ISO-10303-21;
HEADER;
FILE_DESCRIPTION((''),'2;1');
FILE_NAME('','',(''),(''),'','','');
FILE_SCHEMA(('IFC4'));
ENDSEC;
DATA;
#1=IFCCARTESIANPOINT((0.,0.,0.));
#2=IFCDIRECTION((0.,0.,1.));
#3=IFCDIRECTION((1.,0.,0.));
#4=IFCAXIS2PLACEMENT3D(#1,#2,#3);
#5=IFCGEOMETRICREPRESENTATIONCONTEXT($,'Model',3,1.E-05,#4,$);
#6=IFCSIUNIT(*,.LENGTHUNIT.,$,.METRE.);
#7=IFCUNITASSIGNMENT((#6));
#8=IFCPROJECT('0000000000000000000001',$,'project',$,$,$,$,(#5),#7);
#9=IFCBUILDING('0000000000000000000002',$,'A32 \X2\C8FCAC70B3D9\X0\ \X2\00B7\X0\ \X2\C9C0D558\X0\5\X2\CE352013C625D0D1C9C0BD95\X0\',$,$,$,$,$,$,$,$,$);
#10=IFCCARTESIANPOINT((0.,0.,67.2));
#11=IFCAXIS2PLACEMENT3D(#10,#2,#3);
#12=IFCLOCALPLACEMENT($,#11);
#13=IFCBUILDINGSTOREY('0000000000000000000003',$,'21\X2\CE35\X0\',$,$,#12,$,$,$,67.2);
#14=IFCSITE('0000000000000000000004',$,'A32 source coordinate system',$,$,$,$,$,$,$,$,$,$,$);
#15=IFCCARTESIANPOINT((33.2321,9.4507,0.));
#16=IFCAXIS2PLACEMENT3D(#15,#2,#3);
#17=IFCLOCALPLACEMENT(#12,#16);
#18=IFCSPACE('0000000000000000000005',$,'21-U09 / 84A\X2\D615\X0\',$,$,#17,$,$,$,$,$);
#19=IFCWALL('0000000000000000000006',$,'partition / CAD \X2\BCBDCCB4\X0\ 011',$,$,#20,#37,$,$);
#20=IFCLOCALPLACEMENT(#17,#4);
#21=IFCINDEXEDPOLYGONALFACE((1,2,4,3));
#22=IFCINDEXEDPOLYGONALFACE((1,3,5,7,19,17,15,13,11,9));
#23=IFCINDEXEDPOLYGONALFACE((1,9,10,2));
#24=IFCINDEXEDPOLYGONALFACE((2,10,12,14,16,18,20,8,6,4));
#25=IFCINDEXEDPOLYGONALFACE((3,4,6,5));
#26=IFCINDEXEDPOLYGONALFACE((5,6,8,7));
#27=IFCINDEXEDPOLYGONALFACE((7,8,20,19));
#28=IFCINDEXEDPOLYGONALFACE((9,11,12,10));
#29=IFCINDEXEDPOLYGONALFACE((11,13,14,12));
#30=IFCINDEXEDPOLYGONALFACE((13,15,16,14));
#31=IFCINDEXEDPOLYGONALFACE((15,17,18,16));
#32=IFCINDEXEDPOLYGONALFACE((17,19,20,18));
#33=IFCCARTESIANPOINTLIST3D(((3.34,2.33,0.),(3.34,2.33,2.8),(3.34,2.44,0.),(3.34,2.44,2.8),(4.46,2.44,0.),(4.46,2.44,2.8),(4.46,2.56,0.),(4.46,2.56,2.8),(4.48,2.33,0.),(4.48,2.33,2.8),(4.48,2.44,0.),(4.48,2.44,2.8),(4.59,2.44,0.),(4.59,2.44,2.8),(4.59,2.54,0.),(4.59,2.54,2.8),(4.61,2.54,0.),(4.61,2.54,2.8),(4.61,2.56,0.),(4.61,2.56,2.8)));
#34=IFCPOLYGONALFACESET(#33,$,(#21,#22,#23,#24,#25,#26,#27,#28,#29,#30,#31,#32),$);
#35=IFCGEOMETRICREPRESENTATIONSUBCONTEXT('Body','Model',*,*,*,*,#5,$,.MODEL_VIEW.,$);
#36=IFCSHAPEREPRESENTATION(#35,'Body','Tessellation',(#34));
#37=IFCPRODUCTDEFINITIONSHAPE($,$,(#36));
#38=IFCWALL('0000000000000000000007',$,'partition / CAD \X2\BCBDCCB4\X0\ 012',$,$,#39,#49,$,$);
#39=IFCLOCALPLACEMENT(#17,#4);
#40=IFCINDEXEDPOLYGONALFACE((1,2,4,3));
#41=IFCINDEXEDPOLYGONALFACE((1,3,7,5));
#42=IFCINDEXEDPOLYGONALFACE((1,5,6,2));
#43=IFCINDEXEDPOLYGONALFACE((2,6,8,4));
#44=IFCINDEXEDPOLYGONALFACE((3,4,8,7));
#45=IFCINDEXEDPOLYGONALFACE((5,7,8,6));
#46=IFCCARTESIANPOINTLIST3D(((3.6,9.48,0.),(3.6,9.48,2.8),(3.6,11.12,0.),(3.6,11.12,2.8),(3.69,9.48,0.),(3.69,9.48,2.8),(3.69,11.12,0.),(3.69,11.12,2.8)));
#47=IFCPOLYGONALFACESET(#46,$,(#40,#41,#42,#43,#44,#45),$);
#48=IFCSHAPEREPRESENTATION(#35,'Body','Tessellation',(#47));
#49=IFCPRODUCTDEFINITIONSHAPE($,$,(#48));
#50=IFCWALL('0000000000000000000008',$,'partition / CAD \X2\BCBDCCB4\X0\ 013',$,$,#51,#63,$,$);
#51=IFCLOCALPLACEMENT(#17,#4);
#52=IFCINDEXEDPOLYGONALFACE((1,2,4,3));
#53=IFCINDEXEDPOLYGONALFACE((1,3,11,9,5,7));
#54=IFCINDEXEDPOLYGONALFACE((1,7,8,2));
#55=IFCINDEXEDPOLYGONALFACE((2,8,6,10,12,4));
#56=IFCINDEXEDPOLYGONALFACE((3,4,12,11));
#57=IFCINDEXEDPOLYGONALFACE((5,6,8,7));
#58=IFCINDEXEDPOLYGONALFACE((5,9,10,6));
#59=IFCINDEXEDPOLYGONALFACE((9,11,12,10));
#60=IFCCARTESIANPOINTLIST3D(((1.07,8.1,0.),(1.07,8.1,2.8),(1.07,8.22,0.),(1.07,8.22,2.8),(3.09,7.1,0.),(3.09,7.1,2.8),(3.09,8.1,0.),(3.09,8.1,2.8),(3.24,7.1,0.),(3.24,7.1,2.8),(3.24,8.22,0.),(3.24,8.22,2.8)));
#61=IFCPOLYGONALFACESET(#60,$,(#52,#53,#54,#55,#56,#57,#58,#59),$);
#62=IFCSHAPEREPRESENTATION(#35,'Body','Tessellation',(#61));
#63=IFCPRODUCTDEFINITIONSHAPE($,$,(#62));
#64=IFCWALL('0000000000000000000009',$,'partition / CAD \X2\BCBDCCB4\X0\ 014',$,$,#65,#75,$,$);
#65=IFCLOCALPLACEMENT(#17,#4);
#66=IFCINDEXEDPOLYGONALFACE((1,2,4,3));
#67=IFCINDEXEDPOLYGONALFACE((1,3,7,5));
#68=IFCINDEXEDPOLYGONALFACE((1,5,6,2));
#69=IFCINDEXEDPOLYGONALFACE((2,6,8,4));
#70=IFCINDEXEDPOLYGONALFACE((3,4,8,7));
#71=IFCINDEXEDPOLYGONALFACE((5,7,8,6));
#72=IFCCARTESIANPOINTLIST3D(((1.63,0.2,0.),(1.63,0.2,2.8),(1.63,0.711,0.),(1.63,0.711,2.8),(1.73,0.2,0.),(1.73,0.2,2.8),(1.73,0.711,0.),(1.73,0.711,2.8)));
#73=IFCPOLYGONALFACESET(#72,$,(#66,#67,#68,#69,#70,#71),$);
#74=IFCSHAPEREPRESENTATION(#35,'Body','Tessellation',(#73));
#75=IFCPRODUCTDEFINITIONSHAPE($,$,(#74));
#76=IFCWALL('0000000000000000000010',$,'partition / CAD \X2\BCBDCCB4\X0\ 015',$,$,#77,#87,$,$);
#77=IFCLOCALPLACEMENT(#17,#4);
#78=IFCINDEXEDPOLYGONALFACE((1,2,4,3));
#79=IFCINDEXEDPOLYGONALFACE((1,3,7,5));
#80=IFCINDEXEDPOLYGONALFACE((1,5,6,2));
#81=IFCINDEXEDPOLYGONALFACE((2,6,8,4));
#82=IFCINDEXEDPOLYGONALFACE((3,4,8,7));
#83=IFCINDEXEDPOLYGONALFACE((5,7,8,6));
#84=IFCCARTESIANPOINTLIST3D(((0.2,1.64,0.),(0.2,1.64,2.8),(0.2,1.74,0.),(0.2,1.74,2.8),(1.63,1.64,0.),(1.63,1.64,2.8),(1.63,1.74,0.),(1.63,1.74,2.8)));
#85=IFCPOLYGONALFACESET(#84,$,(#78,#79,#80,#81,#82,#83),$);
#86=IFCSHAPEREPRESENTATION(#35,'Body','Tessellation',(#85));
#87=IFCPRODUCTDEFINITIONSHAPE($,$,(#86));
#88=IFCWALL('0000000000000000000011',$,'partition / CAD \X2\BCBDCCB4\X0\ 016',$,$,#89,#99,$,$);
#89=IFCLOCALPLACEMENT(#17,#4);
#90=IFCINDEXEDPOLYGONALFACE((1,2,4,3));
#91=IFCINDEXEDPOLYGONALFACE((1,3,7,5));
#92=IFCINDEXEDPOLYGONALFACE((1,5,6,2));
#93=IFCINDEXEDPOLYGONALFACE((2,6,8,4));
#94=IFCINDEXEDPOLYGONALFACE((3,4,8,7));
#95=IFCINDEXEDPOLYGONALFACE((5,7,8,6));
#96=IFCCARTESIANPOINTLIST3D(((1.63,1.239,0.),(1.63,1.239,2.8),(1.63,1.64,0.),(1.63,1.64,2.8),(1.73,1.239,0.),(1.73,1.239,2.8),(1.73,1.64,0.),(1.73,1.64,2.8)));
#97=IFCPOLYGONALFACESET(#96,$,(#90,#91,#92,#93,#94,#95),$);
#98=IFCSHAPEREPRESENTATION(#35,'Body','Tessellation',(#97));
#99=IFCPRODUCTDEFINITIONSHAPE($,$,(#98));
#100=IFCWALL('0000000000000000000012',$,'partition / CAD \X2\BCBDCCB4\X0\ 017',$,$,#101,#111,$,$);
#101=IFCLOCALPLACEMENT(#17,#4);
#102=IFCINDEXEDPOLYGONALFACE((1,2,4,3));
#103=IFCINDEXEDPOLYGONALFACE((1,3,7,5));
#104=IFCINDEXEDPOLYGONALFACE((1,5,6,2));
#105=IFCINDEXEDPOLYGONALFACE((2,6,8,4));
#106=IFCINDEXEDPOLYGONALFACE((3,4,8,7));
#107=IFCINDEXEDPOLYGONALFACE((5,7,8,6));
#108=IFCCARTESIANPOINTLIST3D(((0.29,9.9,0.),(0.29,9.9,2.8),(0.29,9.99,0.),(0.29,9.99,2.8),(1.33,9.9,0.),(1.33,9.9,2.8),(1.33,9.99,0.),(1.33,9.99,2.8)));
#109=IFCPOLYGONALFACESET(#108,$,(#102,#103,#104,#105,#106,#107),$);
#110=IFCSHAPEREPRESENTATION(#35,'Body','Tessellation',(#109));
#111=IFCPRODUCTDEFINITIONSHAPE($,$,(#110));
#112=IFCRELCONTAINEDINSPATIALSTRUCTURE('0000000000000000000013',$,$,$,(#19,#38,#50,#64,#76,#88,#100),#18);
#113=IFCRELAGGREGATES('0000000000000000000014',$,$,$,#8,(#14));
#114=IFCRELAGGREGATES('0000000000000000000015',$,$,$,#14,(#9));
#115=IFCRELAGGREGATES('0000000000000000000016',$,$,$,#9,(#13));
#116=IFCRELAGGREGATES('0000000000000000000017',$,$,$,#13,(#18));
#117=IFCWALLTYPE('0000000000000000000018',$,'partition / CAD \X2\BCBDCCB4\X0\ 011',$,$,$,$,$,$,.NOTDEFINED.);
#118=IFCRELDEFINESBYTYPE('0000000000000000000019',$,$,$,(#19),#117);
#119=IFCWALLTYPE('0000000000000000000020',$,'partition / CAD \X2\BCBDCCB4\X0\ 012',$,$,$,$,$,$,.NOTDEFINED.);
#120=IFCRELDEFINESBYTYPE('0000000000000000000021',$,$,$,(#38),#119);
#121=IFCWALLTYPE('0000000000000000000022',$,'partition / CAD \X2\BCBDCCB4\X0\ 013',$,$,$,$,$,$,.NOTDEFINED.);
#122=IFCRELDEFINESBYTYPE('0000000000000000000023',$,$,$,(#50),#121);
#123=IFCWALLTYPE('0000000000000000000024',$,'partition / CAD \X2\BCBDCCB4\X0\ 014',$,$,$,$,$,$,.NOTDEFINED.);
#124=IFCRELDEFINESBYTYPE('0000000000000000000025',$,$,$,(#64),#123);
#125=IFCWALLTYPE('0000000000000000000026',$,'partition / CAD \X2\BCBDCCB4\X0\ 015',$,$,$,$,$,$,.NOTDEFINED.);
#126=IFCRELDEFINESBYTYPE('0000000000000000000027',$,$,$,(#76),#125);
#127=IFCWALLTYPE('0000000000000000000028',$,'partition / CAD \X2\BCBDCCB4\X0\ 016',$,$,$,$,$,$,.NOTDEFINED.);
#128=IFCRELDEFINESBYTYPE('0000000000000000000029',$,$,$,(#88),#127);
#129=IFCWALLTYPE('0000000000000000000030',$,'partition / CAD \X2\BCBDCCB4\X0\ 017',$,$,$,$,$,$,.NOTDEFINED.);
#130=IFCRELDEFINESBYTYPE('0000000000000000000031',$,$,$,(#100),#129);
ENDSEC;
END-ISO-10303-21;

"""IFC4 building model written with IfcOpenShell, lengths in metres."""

from ifc_helpers import new_model, si_unit, frame, origin, origin_with_axes, place, context, subcontext, project, spatial, polyline, outline, extrude, source, transform, mapped, type_object, type_shapes, element, save


model = new_model("IFC4")

# Units and contexts
model_context = context("Model", 3, precision=1e-05, world=origin_with_axes())
body_context = subcontext(model_context, "Body", "Model", "MODEL_VIEW")
ifc_project = project(units=[si_unit("LENGTHUNIT", "METRE")], contexts=[model_context])

# Site, building, storey, space
storey_placement = place(None, frame((0.0, 0.0, 67.2), z_axis=(0.0, 0.0, 1.0), x_axis=(1.0, 0.0, 0.0)))
space_placement = place(storey_placement, frame((33.2321, 9.4507, 0.0), z_axis=(0.0, 0.0, 1.0), x_axis=(1.0, 0.0, 0.0)))
site = spatial("IfcSite", under=ifc_project, Name="A32 source coordinate system")
building = spatial("IfcBuilding", under=site, Name="A32 주거동 · 지하5층–옥탑지붕")
storey = spatial("IfcBuildingStorey", under=building, at=storey_placement, Name="21층", Elevation=67.2)
space = spatial("IfcSpace", under=storey, at=space_placement, Name="21-U09 / 84A형")

# Walls
wall_type_1 = type_object("IfcWallType", Name="partition / CAD 벽체 011", PredefinedType="NOTDEFINED")
shared_shape_1 = source(origin(), body_context, "Body", "SweptSolid", [
    extrude(outline(polyline([(3.34, 2.33), (3.34, 2.44), (4.46, 2.44), (4.46, 2.56), (4.61, 2.56), (4.61, 2.54), (4.59, 2.54), (4.59, 2.44), (4.48, 2.44), (4.48, 2.33), (3.34, 2.33)])), origin(), (0.0, 0.0, 1.0), 2.8),
])
type_shapes(wall_type_1, [shared_shape_1])
wall_1_placement = place(space_placement, origin_with_axes())
element("IfcWall", 1, at=wall_1_placement, inside=space, type_object=wall_type_1, Name="partition / CAD 벽체 011", context=body_context, shape_type="MappedRepresentation", body=[
    mapped(shared_shape_1, transform((0.0, 0.0, 0.0), scale=1.0)),
])
wall_type_2 = type_object("IfcWallType", Name="partition / CAD 벽체 012", PredefinedType="NOTDEFINED")
shared_shape_2 = source(origin(), body_context, "Body", "SweptSolid", [
    extrude(outline(polyline([(3.6, 11.12), (3.69, 11.12), (3.69, 9.48), (3.6, 9.48), (3.6, 11.12)])), origin(), (0.0, 0.0, 1.0), 2.8),
])
type_shapes(wall_type_2, [shared_shape_2])
wall_2_placement = place(space_placement, origin_with_axes())
element("IfcWall", 2, at=wall_2_placement, inside=space, type_object=wall_type_2, Name="partition / CAD 벽체 012", context=body_context, shape_type="MappedRepresentation", body=[
    mapped(shared_shape_2, transform((0.0, 0.0, 0.0), scale=1.0)),
])
wall_type_3 = type_object("IfcWallType", Name="partition / CAD 벽체 013", PredefinedType="NOTDEFINED")
shared_shape_3 = source(origin(), body_context, "Body", "SweptSolid", [
    extrude(outline(polyline([(3.09, 8.1), (1.07, 8.1), (1.07, 8.22), (3.24, 8.22), (3.24, 7.1), (3.09, 7.1), (3.09, 8.1)])), origin(), (0.0, 0.0, 1.0), 2.8),
])
type_shapes(wall_type_3, [shared_shape_3])
wall_3_placement = place(space_placement, origin_with_axes())
element("IfcWall", 3, at=wall_3_placement, inside=space, type_object=wall_type_3, Name="partition / CAD 벽체 013", context=body_context, shape_type="MappedRepresentation", body=[
    mapped(shared_shape_3, transform((0.0, 0.0, 0.0), scale=1.0)),
])
wall_type_4 = type_object("IfcWallType", Name="partition / CAD 벽체 014", PredefinedType="NOTDEFINED")
shared_shape_4 = source(origin(), body_context, "Body", "SweptSolid", [
    extrude(outline(polyline([(1.73, 0.2), (1.63, 0.2), (1.63, 0.711), (1.73, 0.711), (1.73, 0.2)])), origin(), (0.0, 0.0, 1.0), 2.8),
])
type_shapes(wall_type_4, [shared_shape_4])
wall_4_placement = place(space_placement, origin_with_axes())
element("IfcWall", 4, at=wall_4_placement, inside=space, type_object=wall_type_4, Name="partition / CAD 벽체 014", context=body_context, shape_type="MappedRepresentation", body=[
    mapped(shared_shape_4, transform((0.0, 0.0, 0.0), scale=1.0)),
])
wall_type_5 = type_object("IfcWallType", Name="partition / CAD 벽체 015", PredefinedType="NOTDEFINED")
shared_shape_5 = source(origin(), body_context, "Body", "SweptSolid", [
    extrude(outline(polyline([(1.63, 1.74), (1.63, 1.64), (0.2, 1.64), (0.2, 1.74), (1.63, 1.74)])), origin(), (0.0, 0.0, 1.0), 2.8),
])
type_shapes(wall_type_5, [shared_shape_5])
wall_5_placement = place(space_placement, origin_with_axes())
element("IfcWall", 5, at=wall_5_placement, inside=space, type_object=wall_type_5, Name="partition / CAD 벽체 015", context=body_context, shape_type="MappedRepresentation", body=[
    mapped(shared_shape_5, transform((0.0, 0.0, 0.0), scale=1.0)),
])
wall_type_6 = type_object("IfcWallType", Name="partition / CAD 벽체 016", PredefinedType="NOTDEFINED")
shared_shape_6 = source(origin(), body_context, "Body", "SweptSolid", [
    extrude(outline(polyline([(1.73, 1.239), (1.63, 1.239), (1.63, 1.64), (1.73, 1.64), (1.73, 1.239)])), origin(), (0.0, 0.0, 1.0), 2.8),
])
type_shapes(wall_type_6, [shared_shape_6])
wall_6_placement = place(space_placement, origin_with_axes())
element("IfcWall", 6, at=wall_6_placement, inside=space, type_object=wall_type_6, Name="partition / CAD 벽체 016", context=body_context, shape_type="MappedRepresentation", body=[
    mapped(shared_shape_6, transform((0.0, 0.0, 0.0), scale=1.0)),
])
wall_type_7 = type_object("IfcWallType", Name="partition / CAD 벽체 017", PredefinedType="NOTDEFINED")
shared_shape_7 = source(origin(), body_context, "Body", "SweptSolid", [
    extrude(outline(polyline([(1.33, 9.99), (1.33, 9.9), (0.29, 9.9), (0.29, 9.99), (1.33, 9.99)])), origin(), (0.0, 0.0, 1.0), 2.8),
])
type_shapes(wall_type_7, [shared_shape_7])
wall_7_placement = place(space_placement, origin_with_axes())
element("IfcWall", 7, at=wall_7_placement, inside=space, type_object=wall_type_7, Name="partition / CAD 벽체 017", context=body_context, shape_type="MappedRepresentation", body=[
    mapped(shared_shape_7, transform((0.0, 0.0, 0.0), scale=1.0)),
])

save(model, "model.ifc")
